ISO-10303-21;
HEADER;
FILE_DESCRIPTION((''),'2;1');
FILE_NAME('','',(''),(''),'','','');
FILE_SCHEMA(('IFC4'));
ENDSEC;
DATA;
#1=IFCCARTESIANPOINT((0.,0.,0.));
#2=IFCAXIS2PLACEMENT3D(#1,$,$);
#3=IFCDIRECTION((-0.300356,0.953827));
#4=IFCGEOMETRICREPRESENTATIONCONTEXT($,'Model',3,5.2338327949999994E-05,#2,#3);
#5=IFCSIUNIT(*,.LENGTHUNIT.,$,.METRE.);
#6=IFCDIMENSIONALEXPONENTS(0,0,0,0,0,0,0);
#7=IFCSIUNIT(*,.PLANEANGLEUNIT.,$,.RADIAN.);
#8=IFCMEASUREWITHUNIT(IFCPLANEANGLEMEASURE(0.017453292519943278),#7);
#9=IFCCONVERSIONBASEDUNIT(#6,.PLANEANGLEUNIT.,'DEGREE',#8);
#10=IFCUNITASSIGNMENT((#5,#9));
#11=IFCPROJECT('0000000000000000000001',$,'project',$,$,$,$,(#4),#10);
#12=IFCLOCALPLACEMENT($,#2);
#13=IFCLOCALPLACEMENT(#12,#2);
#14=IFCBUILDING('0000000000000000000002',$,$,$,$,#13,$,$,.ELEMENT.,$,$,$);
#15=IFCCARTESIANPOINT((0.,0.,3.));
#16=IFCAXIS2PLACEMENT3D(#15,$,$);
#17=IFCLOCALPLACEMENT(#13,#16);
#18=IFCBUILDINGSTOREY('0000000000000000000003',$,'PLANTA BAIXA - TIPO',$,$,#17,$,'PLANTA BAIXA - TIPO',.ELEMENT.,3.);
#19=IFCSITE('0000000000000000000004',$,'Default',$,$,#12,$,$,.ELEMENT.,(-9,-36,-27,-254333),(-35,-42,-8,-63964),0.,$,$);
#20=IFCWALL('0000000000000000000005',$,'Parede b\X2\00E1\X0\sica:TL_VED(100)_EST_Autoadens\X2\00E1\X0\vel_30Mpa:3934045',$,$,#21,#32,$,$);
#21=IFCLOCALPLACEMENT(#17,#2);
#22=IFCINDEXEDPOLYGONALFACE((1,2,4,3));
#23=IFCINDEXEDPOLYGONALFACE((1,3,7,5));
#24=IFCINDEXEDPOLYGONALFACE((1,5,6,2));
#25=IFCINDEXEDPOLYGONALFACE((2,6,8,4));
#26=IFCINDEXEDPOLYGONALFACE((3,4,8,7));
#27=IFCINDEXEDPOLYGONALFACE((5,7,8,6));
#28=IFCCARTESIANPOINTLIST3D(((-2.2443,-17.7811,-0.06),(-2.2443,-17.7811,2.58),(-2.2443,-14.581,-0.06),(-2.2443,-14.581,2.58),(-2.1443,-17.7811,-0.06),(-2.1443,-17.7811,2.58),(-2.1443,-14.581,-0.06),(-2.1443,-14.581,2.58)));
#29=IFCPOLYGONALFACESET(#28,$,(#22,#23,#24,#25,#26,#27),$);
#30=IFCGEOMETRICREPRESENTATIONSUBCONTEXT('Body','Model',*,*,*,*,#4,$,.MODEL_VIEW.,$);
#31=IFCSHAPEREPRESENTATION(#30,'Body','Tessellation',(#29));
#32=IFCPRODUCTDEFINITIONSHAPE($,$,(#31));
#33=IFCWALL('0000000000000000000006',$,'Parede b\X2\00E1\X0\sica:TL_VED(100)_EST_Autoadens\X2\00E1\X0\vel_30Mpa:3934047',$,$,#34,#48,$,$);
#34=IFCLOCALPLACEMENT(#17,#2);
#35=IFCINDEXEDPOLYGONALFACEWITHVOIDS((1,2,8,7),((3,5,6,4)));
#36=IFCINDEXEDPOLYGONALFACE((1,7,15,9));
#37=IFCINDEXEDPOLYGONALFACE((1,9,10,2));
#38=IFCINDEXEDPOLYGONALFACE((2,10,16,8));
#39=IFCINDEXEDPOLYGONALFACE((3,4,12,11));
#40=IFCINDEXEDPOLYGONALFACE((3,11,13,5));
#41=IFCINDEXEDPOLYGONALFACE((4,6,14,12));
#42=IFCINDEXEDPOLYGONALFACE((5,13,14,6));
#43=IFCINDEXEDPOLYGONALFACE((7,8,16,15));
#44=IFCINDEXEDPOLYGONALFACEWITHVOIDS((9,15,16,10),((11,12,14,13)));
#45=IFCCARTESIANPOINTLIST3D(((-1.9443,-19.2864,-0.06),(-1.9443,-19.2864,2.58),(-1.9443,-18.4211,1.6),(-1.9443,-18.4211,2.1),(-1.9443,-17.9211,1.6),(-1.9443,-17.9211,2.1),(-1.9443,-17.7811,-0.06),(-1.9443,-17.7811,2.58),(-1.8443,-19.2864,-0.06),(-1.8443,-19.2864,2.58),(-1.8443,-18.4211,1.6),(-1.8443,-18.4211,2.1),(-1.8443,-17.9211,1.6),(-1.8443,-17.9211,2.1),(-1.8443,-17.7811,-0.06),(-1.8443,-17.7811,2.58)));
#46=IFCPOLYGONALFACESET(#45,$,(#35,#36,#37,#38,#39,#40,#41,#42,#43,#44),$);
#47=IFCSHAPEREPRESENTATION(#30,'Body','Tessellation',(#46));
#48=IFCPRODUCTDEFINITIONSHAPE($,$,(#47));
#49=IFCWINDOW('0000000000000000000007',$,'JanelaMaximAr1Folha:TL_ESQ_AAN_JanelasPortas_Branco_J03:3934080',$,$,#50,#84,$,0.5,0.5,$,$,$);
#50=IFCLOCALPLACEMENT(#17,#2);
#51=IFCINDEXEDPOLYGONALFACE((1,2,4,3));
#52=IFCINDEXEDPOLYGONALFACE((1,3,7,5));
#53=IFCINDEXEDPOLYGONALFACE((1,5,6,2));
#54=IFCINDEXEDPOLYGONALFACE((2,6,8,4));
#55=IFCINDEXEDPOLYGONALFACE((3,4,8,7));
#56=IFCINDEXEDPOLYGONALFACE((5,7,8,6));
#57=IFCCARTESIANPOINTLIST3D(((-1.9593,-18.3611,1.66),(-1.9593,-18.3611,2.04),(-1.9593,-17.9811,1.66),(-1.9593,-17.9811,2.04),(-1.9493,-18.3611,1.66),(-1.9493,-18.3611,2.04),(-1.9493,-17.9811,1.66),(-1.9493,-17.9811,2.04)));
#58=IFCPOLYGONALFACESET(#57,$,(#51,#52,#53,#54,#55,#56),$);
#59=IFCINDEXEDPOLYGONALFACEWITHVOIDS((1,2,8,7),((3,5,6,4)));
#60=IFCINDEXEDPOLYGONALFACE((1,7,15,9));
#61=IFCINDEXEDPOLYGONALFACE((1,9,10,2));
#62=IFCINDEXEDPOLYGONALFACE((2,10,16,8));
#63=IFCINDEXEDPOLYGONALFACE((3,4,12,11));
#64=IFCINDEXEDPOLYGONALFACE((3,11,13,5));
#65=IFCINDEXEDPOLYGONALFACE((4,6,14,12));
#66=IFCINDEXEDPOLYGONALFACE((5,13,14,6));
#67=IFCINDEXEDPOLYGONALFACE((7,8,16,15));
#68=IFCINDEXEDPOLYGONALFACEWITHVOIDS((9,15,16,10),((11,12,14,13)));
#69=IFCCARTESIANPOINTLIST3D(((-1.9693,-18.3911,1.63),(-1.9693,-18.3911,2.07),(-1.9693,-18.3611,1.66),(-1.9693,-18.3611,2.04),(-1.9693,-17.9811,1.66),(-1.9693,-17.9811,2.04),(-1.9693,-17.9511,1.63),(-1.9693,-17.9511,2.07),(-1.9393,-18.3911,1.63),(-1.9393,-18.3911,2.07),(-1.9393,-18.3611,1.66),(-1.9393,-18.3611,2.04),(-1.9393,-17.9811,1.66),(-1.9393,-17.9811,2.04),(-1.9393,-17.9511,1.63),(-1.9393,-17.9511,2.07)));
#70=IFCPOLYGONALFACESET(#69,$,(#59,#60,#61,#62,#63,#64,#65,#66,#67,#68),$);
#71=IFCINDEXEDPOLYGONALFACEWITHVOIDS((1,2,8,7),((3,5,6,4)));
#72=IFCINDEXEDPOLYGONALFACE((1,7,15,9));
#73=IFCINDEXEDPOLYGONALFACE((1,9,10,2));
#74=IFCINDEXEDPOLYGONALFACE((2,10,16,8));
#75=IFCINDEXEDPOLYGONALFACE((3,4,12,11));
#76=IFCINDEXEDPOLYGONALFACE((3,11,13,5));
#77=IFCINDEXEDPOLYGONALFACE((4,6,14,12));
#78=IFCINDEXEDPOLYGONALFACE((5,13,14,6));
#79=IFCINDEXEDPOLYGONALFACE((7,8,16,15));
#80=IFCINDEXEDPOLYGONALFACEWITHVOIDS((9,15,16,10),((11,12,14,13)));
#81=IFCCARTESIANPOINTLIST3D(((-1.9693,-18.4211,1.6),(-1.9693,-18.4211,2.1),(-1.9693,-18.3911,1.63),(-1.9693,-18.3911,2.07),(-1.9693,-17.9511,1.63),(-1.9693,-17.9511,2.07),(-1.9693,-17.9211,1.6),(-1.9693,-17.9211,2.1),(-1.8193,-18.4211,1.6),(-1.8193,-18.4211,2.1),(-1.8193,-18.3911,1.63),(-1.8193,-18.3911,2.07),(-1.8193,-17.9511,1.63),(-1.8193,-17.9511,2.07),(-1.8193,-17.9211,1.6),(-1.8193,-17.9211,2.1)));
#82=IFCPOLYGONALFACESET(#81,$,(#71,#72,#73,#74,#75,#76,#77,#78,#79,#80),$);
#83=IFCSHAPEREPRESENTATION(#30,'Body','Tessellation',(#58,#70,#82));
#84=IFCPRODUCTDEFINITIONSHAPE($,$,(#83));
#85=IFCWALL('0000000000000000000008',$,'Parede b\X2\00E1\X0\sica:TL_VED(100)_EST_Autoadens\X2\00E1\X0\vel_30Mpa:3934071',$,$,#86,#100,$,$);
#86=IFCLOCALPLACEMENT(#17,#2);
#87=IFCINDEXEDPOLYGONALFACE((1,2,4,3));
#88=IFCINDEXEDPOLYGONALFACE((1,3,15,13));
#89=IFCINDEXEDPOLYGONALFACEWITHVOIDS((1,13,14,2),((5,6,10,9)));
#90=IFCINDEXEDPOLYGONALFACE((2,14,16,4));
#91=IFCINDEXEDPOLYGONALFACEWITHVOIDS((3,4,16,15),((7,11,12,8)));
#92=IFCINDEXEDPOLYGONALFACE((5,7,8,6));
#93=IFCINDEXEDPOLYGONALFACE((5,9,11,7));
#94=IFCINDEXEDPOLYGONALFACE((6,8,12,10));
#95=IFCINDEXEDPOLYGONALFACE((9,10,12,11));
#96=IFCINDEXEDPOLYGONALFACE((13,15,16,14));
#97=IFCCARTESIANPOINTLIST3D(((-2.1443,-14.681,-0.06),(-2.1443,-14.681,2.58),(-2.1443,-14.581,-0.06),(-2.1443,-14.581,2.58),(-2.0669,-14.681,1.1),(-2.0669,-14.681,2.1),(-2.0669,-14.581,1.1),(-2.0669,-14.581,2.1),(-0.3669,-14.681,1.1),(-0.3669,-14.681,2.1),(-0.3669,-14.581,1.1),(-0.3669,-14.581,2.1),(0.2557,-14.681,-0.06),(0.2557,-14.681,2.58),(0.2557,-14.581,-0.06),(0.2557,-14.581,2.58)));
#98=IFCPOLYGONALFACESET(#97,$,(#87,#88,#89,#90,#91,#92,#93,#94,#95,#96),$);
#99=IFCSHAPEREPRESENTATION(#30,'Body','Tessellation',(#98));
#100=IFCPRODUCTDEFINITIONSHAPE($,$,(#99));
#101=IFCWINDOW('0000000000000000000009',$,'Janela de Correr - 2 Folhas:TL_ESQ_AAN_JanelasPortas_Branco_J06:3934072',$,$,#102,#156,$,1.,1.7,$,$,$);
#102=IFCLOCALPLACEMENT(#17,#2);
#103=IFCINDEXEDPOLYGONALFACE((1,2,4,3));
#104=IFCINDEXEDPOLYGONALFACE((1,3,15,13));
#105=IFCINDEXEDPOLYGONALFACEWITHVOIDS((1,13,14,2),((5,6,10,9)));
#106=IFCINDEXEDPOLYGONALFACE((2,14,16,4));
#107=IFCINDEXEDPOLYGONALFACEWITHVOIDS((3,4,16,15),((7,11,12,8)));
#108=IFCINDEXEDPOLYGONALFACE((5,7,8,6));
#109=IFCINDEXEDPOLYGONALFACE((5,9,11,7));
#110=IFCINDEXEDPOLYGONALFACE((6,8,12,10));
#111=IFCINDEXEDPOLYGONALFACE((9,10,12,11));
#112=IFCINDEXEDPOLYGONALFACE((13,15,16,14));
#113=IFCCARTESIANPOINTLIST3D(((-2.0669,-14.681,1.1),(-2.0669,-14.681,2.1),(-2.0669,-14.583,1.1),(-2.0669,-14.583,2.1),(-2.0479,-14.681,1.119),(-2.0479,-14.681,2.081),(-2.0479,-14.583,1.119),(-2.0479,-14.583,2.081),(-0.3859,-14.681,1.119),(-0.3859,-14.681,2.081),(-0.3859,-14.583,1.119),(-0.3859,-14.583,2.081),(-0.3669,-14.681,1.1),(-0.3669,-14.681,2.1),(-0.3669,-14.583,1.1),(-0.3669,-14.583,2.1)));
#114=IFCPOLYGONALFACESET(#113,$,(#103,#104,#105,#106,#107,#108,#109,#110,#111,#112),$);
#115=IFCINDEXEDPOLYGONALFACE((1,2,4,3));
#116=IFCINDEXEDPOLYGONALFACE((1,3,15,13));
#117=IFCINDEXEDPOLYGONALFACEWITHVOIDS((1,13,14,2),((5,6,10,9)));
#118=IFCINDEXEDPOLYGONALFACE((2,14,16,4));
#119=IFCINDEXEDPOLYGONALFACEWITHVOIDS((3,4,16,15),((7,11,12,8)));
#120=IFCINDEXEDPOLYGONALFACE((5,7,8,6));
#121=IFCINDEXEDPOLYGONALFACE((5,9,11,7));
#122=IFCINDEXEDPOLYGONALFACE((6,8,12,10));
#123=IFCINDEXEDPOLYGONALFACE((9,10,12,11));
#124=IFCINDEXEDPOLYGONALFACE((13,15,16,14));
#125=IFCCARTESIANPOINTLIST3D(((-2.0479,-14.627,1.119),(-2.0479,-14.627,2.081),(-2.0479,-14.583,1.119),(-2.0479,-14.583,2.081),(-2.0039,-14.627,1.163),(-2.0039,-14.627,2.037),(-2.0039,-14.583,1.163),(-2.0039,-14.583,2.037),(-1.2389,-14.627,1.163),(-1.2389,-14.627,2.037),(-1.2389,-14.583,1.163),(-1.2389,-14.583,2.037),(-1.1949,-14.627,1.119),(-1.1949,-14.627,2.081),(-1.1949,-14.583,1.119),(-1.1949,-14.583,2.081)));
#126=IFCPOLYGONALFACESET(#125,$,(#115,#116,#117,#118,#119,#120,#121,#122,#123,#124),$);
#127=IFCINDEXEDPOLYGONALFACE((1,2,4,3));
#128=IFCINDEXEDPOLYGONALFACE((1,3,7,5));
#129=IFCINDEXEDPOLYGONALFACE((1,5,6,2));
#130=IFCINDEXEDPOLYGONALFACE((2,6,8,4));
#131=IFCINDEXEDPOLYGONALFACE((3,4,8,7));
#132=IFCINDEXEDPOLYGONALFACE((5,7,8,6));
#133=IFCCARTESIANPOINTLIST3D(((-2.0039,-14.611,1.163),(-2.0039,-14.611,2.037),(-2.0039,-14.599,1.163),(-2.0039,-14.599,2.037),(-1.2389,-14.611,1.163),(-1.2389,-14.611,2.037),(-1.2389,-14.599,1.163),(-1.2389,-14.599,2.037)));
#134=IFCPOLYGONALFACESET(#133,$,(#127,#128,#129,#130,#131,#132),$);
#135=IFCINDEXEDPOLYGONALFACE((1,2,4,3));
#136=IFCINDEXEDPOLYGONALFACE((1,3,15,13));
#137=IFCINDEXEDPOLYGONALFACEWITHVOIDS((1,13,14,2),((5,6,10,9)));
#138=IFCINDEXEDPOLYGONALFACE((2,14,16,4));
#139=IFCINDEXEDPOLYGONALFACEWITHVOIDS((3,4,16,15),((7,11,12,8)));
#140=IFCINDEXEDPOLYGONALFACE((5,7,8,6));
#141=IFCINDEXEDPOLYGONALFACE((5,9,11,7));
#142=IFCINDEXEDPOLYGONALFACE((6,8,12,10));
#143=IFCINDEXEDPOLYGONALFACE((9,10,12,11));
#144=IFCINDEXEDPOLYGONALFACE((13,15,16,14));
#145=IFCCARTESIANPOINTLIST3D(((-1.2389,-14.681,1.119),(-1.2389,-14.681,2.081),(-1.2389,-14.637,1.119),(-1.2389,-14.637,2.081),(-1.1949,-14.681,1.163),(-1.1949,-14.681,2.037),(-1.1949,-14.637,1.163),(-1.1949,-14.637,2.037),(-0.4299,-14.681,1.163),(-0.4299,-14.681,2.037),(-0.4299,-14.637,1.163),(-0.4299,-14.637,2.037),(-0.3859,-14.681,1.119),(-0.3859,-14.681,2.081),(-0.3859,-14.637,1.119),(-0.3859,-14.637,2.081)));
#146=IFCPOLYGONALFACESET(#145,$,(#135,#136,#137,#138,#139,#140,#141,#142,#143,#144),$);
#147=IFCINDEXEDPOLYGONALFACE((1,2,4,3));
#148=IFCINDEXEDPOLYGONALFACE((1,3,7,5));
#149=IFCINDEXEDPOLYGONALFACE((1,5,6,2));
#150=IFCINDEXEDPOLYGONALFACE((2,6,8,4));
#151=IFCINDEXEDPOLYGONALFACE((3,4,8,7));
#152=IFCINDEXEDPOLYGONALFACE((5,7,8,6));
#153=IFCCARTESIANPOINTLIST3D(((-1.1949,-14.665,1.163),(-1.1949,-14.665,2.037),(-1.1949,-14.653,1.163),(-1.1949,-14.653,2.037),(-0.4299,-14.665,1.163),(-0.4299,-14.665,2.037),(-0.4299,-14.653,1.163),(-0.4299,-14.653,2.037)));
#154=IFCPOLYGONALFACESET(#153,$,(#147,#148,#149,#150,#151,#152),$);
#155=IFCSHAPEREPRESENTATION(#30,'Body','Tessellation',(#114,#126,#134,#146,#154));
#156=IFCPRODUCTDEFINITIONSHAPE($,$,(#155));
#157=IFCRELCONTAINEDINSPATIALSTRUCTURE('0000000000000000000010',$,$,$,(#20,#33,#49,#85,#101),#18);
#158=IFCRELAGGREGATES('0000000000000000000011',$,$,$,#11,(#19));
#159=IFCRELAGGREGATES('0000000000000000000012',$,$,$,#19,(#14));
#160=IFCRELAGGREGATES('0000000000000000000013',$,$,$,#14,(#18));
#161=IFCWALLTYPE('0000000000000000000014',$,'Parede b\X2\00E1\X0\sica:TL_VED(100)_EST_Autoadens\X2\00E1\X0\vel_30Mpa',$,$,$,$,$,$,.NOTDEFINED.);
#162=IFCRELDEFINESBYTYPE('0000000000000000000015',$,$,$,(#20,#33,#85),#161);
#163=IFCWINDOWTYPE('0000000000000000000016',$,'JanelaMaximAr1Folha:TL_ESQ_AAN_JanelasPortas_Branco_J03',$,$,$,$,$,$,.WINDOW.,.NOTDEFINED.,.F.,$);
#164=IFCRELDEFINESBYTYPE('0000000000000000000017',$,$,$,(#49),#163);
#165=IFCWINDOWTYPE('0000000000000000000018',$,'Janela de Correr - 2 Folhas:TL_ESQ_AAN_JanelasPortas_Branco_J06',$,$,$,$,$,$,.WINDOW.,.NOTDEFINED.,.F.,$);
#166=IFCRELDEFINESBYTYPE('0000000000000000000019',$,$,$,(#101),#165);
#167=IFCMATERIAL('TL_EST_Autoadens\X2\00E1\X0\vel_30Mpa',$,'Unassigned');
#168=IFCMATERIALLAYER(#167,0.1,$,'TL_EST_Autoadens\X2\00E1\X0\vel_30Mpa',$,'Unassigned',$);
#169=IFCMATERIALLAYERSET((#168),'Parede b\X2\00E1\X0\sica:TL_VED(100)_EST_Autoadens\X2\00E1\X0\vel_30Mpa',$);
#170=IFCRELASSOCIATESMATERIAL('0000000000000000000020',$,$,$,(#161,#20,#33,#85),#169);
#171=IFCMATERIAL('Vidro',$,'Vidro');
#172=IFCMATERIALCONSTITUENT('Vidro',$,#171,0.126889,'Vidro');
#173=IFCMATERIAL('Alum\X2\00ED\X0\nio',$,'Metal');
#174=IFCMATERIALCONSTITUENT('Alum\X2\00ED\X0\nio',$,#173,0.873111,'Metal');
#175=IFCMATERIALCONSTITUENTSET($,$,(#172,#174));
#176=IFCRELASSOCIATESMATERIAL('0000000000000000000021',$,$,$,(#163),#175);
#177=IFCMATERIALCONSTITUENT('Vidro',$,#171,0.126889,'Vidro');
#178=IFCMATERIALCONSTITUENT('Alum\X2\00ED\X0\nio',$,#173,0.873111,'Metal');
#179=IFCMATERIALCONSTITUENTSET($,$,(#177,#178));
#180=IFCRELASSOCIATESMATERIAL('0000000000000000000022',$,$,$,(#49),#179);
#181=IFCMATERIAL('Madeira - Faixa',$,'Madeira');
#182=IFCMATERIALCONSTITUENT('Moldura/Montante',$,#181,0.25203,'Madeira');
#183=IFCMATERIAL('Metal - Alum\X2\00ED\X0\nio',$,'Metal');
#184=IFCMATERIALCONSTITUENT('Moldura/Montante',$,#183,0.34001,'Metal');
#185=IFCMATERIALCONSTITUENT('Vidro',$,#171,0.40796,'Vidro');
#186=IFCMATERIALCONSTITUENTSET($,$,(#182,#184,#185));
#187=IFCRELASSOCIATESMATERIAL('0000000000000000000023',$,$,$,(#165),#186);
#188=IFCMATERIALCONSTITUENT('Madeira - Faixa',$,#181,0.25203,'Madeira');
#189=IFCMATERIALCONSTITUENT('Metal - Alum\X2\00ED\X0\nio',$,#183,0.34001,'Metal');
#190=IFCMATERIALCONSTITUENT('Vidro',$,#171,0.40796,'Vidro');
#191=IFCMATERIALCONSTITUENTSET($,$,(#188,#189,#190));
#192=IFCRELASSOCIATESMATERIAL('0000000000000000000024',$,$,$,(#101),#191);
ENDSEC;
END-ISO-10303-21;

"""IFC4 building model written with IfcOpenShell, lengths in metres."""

from ifc_helpers import new_model, entity, si_unit, converted_unit, direction, frame, frame_2d, origin, origin_2d_with_axis, place, context, subcontext, project, spatial, polyline, rectangle, outline, extrude, source, transform, mapped, material, layer, layer_set, layer_usage, constituent, constituent_set, type_object, type_shapes, element, fill, save


model = new_model("IFC4")

# Units and contexts
model_context = context("Model", 3, precision=5.2338327949999994e-05, world=origin(), true_north=direction((-0.300356, 0.953827)))
body_context = subcontext(model_context, "Body", "Model", "MODEL_VIEW")
ifc_project = project(units=[si_unit("LENGTHUNIT", "METRE"), converted_unit("PLANEANGLEUNIT", "DEGREE", entity("IfcPlaneAngleMeasure", 0.017453292519943278), si_unit("PLANEANGLEUNIT", "RADIAN"), dimensions=[0, 0, 0, 0, 0, 0, 0])], contexts=[model_context])

# Site, building, storey
site_placement = place(None, origin())
site = spatial("IfcSite", under=ifc_project, at=site_placement, Name="Default", CompositionType="ELEMENT", RefLatitude=(-9, -36, -27, -254333), RefLongitude=(-35, -42, -8, -63964), RefElevation=0.0)
building_placement = place(site_placement, origin())
building = spatial("IfcBuilding", under=site, at=building_placement, CompositionType="ELEMENT")
storey_placement = place(building_placement, frame((0.0, 0.0, 3.0)))
storey = spatial("IfcBuildingStorey", under=building, at=storey_placement, Name="PLANTA BAIXA - TIPO", LongName="PLANTA BAIXA - TIPO", CompositionType="ELEMENT", Elevation=3.0)

# Wall
ifc_material_1 = material(Name="TL_EST_Autoadensável_30Mpa", Category="Unassigned")
ifc_layer_1 = layer(ifc_material_1, 0.1, Name="TL_EST_Autoadensável_30Mpa", Category="Unassigned")
ifc_layer_set_1 = layer_set([ifc_layer_1], Name="Parede básica:TL_VED(100)_EST_Autoadensável_30Mpa")
ifc_layer_usage_1 = layer_usage(ifc_layer_set_1, "AXIS2", "NEGATIVE", 0.05)
wall_type_1 = type_object("IfcWallType", Name="Parede básica:TL_VED(100)_EST_Autoadensável_30Mpa", PredefinedType="NOTDEFINED", material=ifc_layer_set_1)
wall_1_placement = place(storey_placement, frame((-2.1943, -14.581, -0.06), z_axis=(0.0, 0.0, 1.0), x_axis=(0.0, -1.0, 0.0)))
element("IfcWall", 1, at=wall_1_placement, inside=storey, type_object=wall_type_1, material=ifc_layer_usage_1, Name="Parede básica:TL_VED(100)_EST_Autoadensável_30Mpa:3934045", context=body_context, shape_type="SweptSolid", body=[
    extrude(rectangle(XDim=3.2001, YDim=0.1, at=frame_2d((1.6001, 0.0), x_axis=(-1.0, 0.0))), origin(), (0.0, 0.0, 1.0), 2.64),
])

# Walls, openings, windows
ifc_layer_usage_2 = layer_usage(ifc_layer_set_1, "AXIS2", "NEGATIVE", 0.05)
wall_2_placement = place(storey_placement, frame((-1.8943, -19.2864, -0.06), z_axis=(0.0, 0.0, 1.0), x_axis=(0.0, 1.0, 0.0)))
wall_2 = element("IfcWall", 2, at=wall_2_placement, inside=storey, type_object=wall_type_1, material=ifc_layer_usage_2, Name="Parede básica:TL_VED(100)_EST_Autoadensável_30Mpa:3934047", context=body_context, shape_type="SweptSolid", body=[
    extrude(rectangle(XDim=1.5052, YDim=0.1, at=frame_2d((0.7526, 0.0), x_axis=(-1.0, 0.0))), origin(), (0.0, 0.0, 1.0), 2.64),
])
opening_1_placement = place(wall_2_placement, frame((1.3652, 0.05, 1.66)))
opening_1 = element("IfcOpeningElement", 3, at=opening_1_placement, cuts=wall_2, PredefinedType="OPENING", context=body_context, shape_type="SweptSolid", body=[
    extrude(rectangle(XDim=0.5, YDim=0.5, at=frame_2d((0.25, 0.25), x_axis=(1.0, 0.0))), frame((0.0, 0.0, 0.0), z_axis=(0.0, -1.0, 0.0), x_axis=(0.0, 0.0, 1.0)), (0.0, 0.0, 1.0), 0.1),
])
ifc_material_2 = material(Name="Vidro", Category="Vidro")
ifc_constituent_1 = constituent(ifc_material_2, Name="Vidro", Category="Vidro", fraction=0.126889)
ifc_material_3 = material(Name="Alumínio", Category="Metal")
ifc_constituent_2 = constituent(ifc_material_3, Name="Alumínio", Category="Metal", fraction=0.873111)
ifc_constituent_set_1 = constituent_set(constituents=[ifc_constituent_1, ifc_constituent_2])
ifc_constituent_3 = constituent(ifc_material_2, Name="Vidro", Category="Vidro", fraction=0.126889)
ifc_constituent_4 = constituent(ifc_material_3, Name="Alumínio", Category="Metal", fraction=0.873111)
ifc_constituent_set_2 = constituent_set(constituents=[ifc_constituent_3, ifc_constituent_4])
window_type_1 = type_object("IfcWindowType", Name="JanelaMaximAr1Folha:TL_ESQ_AAN_JanelasPortas_Branco_J03", ParameterTakesPrecedence=False, PartitioningType="NOTDEFINED", PredefinedType="WINDOW", material=ifc_constituent_set_2)
shared_shape_1 = source(origin(), body_context, "Body", "SweptSolid", [
    extrude(rectangle(XDim=0.01, YDim=0.38, at=frame_2d((0.0, 0.0), x_axis=(1.0, 0.0))), frame((0.25, -0.01, 0.06), z_axis=(0.0, 0.0, 1.0), x_axis=(0.0, 1.0, 0.0)), (0.0, 0.0, 1.0), 0.38),
    extrude(outline(polyline([(-0.22, -0.22), (0.22, -0.22), (0.22, 0.22), (-0.22, 0.22), (-0.22, -0.22)]), holes=[polyline([(0.19, 0.19), (0.19, -0.19), (-0.19, -0.19), (-0.19, 0.19), (0.19, 0.19)])]), frame((0.25, -0.025, 0.25), z_axis=(0.0, 1.0, 0.0), x_axis=(0.0, 0.0, -1.0)), (0.0, 0.0, 1.0), 0.03),
    extrude(outline(polyline([(-0.25, -0.25), (0.25, -0.25), (0.25, 0.25), (-0.25, 0.25), (-0.25, -0.25)]), holes=[polyline([(-0.22, -0.22), (-0.22, 0.22), (0.22, 0.22), (0.22, -0.22), (-0.22, -0.22)])]), frame((0.25, -0.025, 0.25), z_axis=(0.0, 1.0, 0.0), x_axis=(0.0, 0.0, -1.0)), (0.0, 0.0, 1.0), 0.15),
])
type_shapes(window_type_1, [shared_shape_1])
window_1_placement = place(opening_1_placement, frame((0.0, 0.0, 0.0), z_axis=(0.0, 0.0, 1.0), x_axis=(-1.0, 0.0, 0.0)))
window_1 = element("IfcWindow", 4, at=window_1_placement, inside=storey, type_object=window_type_1, material=ifc_constituent_set_1, Name="JanelaMaximAr1Folha:TL_ESQ_AAN_JanelasPortas_Branco_J03:3934080", OverallHeight=0.5, OverallWidth=0.5, context=body_context, shape_type="MappedRepresentation", body=[
    mapped(shared_shape_1, transform((0.0, 0.0, 0.0), scale=1.0)),
])
fill(opening_1, window_1)
ifc_layer_usage_3 = layer_usage(ifc_layer_set_1, "AXIS2", "NEGATIVE", 0.05)
wall_3_placement = place(storey_placement, frame((-2.1443, -14.631, -0.06)))
wall_3 = element("IfcWall", 5, at=wall_3_placement, inside=storey, type_object=wall_type_1, material=ifc_layer_usage_3, Name="Parede básica:TL_VED(100)_EST_Autoadensável_30Mpa:3934071", context=body_context, shape_type="SweptSolid", body=[
    extrude(rectangle(XDim=2.4, YDim=0.1, at=frame_2d((1.2, 0.0), x_axis=(-1.0, 0.0))), origin(), (0.0, 0.0, 1.0), 2.64),
])
opening_2_placement = place(wall_3_placement, frame((0.0774, -0.05, 1.16)))
opening_2 = element("IfcOpeningElement", 6, at=opening_2_placement, cuts=wall_3, PredefinedType="OPENING", context=body_context, shape_type="SweptSolid", body=[
    extrude(rectangle(XDim=1.0, YDim=1.7, at=frame_2d((0.5, 0.85), x_axis=(-1.0, 0.0))), frame((0.0, 0.0, 0.0), z_axis=(0.0, 1.0, 0.0), x_axis=(0.0, 0.0, 1.0)), (0.0, 0.0, 1.0), 0.1),
])
ifc_material_4 = material(Name="Madeira - Faixa", Category="Madeira")
ifc_constituent_5 = constituent(ifc_material_4, Name="Madeira - Faixa", Category="Madeira", fraction=0.25203)
ifc_material_5 = material(Name="Metal - Alumínio", Category="Metal")
ifc_constituent_6 = constituent(ifc_material_5, Name="Metal - Alumínio", Category="Metal", fraction=0.34001)
ifc_constituent_7 = constituent(ifc_material_2, Name="Vidro", Category="Vidro", fraction=0.40796)
ifc_constituent_set_3 = constituent_set(constituents=[ifc_constituent_5, ifc_constituent_6, ifc_constituent_7])
ifc_constituent_8 = constituent(ifc_material_4, Name="Moldura/Montante", Category="Madeira", fraction=0.25203)
ifc_constituent_9 = constituent(ifc_material_5, Name="Moldura/Montante", Category="Metal", fraction=0.34001)
ifc_constituent_10 = constituent(ifc_material_2, Name="Vidro", Category="Vidro", fraction=0.40796)
ifc_constituent_set_4 = constituent_set(constituents=[ifc_constituent_8, ifc_constituent_9, ifc_constituent_10])
window_type_2 = type_object("IfcWindowType", Name="Janela de Correr - 2 Folhas:TL_ESQ_AAN_JanelasPortas_Branco_J06", ParameterTakesPrecedence=False, PartitioningType="NOTDEFINED", PredefinedType="WINDOW", material=ifc_constituent_set_4)
shared_shape_2 = source(origin(), body_context, "Body", "SweptSolid", [
    extrude(outline(polyline([(-0.85, -0.5), (0.85, -0.5), (0.85, 0.5), (-0.85, 0.5), (-0.85, -0.5)]), holes=[polyline([(-0.831, -0.481), (-0.831, 0.481), (0.831, 0.481), (0.831, -0.481), (-0.831, -0.481)])]), frame((0.85, 0.124, 0.5), z_axis=(0.0, -1.0, 0.0), x_axis=(-1.0, 0.0, 0.0)), (0.0, 0.0, 1.0), 0.098),
    extrude(outline(polyline([(-0.4265, -0.481), (0.4265, -0.481), (0.4265, 0.481), (-0.4265, 0.481), (-0.4265, -0.481)]), holes=[polyline([(-0.3825, -0.437), (-0.3825, 0.437), (0.3825, 0.437), (0.3825, -0.437), (-0.3825, -0.437)])]), frame((0.4455, 0.124, 0.5), z_axis=(0.0, -1.0, 0.0), x_axis=(-1.0, 0.0, 0.0)), (0.0, 0.0, 1.0), 0.044),
    extrude(rectangle(XDim=0.765, YDim=0.012, at=origin_2d_with_axis()), frame((0.4455, 0.102, 0.063), z_axis=(0.0, 0.0, 1.0), x_axis=(-1.0, 0.0, 0.0)), (0.0, 0.0, 1.0), 0.874),
    extrude(outline(polyline([(-0.481, -0.4265), (0.481, -0.4265), (0.481, 0.4265), (-0.481, 0.4265), (-0.481, -0.4265)]), holes=[polyline([(-0.437, -0.3825), (-0.437, 0.3825), (0.437, 0.3825), (0.437, -0.3825), (-0.437, -0.3825)])]), frame((1.2545, 0.07, 0.5), z_axis=(0.0, -1.0, 0.0), x_axis=(0.0, 0.0, -1.0)), (0.0, 0.0, 1.0), 0.044),
    extrude(rectangle(XDim=0.765, YDim=0.012, at=origin_2d_with_axis()), frame((1.2545, 0.048, 0.063), z_axis=(0.0, 0.0, 1.0), x_axis=(-1.0, 0.0, 0.0)), (0.0, 0.0, 1.0), 0.874),
])
type_shapes(window_type_2, [shared_shape_2])
window_2_placement = place(opening_2_placement, frame((0.0, -0.026, 0.0)))
window_2 = element("IfcWindow", 7, at=window_2_placement, inside=storey, type_object=window_type_2, material=ifc_constituent_set_3, Name="Janela de Correr - 2 Folhas:TL_ESQ_AAN_JanelasPortas_Branco_J06:3934072", OverallHeight=1.0, OverallWidth=1.7, context=body_context, shape_type="MappedRepresentation", body=[
    mapped(shared_shape_2, transform((0.0, 0.0, 0.0), scale=1.0)),
])
fill(opening_2, window_2)

save(model, "model.ifc")
